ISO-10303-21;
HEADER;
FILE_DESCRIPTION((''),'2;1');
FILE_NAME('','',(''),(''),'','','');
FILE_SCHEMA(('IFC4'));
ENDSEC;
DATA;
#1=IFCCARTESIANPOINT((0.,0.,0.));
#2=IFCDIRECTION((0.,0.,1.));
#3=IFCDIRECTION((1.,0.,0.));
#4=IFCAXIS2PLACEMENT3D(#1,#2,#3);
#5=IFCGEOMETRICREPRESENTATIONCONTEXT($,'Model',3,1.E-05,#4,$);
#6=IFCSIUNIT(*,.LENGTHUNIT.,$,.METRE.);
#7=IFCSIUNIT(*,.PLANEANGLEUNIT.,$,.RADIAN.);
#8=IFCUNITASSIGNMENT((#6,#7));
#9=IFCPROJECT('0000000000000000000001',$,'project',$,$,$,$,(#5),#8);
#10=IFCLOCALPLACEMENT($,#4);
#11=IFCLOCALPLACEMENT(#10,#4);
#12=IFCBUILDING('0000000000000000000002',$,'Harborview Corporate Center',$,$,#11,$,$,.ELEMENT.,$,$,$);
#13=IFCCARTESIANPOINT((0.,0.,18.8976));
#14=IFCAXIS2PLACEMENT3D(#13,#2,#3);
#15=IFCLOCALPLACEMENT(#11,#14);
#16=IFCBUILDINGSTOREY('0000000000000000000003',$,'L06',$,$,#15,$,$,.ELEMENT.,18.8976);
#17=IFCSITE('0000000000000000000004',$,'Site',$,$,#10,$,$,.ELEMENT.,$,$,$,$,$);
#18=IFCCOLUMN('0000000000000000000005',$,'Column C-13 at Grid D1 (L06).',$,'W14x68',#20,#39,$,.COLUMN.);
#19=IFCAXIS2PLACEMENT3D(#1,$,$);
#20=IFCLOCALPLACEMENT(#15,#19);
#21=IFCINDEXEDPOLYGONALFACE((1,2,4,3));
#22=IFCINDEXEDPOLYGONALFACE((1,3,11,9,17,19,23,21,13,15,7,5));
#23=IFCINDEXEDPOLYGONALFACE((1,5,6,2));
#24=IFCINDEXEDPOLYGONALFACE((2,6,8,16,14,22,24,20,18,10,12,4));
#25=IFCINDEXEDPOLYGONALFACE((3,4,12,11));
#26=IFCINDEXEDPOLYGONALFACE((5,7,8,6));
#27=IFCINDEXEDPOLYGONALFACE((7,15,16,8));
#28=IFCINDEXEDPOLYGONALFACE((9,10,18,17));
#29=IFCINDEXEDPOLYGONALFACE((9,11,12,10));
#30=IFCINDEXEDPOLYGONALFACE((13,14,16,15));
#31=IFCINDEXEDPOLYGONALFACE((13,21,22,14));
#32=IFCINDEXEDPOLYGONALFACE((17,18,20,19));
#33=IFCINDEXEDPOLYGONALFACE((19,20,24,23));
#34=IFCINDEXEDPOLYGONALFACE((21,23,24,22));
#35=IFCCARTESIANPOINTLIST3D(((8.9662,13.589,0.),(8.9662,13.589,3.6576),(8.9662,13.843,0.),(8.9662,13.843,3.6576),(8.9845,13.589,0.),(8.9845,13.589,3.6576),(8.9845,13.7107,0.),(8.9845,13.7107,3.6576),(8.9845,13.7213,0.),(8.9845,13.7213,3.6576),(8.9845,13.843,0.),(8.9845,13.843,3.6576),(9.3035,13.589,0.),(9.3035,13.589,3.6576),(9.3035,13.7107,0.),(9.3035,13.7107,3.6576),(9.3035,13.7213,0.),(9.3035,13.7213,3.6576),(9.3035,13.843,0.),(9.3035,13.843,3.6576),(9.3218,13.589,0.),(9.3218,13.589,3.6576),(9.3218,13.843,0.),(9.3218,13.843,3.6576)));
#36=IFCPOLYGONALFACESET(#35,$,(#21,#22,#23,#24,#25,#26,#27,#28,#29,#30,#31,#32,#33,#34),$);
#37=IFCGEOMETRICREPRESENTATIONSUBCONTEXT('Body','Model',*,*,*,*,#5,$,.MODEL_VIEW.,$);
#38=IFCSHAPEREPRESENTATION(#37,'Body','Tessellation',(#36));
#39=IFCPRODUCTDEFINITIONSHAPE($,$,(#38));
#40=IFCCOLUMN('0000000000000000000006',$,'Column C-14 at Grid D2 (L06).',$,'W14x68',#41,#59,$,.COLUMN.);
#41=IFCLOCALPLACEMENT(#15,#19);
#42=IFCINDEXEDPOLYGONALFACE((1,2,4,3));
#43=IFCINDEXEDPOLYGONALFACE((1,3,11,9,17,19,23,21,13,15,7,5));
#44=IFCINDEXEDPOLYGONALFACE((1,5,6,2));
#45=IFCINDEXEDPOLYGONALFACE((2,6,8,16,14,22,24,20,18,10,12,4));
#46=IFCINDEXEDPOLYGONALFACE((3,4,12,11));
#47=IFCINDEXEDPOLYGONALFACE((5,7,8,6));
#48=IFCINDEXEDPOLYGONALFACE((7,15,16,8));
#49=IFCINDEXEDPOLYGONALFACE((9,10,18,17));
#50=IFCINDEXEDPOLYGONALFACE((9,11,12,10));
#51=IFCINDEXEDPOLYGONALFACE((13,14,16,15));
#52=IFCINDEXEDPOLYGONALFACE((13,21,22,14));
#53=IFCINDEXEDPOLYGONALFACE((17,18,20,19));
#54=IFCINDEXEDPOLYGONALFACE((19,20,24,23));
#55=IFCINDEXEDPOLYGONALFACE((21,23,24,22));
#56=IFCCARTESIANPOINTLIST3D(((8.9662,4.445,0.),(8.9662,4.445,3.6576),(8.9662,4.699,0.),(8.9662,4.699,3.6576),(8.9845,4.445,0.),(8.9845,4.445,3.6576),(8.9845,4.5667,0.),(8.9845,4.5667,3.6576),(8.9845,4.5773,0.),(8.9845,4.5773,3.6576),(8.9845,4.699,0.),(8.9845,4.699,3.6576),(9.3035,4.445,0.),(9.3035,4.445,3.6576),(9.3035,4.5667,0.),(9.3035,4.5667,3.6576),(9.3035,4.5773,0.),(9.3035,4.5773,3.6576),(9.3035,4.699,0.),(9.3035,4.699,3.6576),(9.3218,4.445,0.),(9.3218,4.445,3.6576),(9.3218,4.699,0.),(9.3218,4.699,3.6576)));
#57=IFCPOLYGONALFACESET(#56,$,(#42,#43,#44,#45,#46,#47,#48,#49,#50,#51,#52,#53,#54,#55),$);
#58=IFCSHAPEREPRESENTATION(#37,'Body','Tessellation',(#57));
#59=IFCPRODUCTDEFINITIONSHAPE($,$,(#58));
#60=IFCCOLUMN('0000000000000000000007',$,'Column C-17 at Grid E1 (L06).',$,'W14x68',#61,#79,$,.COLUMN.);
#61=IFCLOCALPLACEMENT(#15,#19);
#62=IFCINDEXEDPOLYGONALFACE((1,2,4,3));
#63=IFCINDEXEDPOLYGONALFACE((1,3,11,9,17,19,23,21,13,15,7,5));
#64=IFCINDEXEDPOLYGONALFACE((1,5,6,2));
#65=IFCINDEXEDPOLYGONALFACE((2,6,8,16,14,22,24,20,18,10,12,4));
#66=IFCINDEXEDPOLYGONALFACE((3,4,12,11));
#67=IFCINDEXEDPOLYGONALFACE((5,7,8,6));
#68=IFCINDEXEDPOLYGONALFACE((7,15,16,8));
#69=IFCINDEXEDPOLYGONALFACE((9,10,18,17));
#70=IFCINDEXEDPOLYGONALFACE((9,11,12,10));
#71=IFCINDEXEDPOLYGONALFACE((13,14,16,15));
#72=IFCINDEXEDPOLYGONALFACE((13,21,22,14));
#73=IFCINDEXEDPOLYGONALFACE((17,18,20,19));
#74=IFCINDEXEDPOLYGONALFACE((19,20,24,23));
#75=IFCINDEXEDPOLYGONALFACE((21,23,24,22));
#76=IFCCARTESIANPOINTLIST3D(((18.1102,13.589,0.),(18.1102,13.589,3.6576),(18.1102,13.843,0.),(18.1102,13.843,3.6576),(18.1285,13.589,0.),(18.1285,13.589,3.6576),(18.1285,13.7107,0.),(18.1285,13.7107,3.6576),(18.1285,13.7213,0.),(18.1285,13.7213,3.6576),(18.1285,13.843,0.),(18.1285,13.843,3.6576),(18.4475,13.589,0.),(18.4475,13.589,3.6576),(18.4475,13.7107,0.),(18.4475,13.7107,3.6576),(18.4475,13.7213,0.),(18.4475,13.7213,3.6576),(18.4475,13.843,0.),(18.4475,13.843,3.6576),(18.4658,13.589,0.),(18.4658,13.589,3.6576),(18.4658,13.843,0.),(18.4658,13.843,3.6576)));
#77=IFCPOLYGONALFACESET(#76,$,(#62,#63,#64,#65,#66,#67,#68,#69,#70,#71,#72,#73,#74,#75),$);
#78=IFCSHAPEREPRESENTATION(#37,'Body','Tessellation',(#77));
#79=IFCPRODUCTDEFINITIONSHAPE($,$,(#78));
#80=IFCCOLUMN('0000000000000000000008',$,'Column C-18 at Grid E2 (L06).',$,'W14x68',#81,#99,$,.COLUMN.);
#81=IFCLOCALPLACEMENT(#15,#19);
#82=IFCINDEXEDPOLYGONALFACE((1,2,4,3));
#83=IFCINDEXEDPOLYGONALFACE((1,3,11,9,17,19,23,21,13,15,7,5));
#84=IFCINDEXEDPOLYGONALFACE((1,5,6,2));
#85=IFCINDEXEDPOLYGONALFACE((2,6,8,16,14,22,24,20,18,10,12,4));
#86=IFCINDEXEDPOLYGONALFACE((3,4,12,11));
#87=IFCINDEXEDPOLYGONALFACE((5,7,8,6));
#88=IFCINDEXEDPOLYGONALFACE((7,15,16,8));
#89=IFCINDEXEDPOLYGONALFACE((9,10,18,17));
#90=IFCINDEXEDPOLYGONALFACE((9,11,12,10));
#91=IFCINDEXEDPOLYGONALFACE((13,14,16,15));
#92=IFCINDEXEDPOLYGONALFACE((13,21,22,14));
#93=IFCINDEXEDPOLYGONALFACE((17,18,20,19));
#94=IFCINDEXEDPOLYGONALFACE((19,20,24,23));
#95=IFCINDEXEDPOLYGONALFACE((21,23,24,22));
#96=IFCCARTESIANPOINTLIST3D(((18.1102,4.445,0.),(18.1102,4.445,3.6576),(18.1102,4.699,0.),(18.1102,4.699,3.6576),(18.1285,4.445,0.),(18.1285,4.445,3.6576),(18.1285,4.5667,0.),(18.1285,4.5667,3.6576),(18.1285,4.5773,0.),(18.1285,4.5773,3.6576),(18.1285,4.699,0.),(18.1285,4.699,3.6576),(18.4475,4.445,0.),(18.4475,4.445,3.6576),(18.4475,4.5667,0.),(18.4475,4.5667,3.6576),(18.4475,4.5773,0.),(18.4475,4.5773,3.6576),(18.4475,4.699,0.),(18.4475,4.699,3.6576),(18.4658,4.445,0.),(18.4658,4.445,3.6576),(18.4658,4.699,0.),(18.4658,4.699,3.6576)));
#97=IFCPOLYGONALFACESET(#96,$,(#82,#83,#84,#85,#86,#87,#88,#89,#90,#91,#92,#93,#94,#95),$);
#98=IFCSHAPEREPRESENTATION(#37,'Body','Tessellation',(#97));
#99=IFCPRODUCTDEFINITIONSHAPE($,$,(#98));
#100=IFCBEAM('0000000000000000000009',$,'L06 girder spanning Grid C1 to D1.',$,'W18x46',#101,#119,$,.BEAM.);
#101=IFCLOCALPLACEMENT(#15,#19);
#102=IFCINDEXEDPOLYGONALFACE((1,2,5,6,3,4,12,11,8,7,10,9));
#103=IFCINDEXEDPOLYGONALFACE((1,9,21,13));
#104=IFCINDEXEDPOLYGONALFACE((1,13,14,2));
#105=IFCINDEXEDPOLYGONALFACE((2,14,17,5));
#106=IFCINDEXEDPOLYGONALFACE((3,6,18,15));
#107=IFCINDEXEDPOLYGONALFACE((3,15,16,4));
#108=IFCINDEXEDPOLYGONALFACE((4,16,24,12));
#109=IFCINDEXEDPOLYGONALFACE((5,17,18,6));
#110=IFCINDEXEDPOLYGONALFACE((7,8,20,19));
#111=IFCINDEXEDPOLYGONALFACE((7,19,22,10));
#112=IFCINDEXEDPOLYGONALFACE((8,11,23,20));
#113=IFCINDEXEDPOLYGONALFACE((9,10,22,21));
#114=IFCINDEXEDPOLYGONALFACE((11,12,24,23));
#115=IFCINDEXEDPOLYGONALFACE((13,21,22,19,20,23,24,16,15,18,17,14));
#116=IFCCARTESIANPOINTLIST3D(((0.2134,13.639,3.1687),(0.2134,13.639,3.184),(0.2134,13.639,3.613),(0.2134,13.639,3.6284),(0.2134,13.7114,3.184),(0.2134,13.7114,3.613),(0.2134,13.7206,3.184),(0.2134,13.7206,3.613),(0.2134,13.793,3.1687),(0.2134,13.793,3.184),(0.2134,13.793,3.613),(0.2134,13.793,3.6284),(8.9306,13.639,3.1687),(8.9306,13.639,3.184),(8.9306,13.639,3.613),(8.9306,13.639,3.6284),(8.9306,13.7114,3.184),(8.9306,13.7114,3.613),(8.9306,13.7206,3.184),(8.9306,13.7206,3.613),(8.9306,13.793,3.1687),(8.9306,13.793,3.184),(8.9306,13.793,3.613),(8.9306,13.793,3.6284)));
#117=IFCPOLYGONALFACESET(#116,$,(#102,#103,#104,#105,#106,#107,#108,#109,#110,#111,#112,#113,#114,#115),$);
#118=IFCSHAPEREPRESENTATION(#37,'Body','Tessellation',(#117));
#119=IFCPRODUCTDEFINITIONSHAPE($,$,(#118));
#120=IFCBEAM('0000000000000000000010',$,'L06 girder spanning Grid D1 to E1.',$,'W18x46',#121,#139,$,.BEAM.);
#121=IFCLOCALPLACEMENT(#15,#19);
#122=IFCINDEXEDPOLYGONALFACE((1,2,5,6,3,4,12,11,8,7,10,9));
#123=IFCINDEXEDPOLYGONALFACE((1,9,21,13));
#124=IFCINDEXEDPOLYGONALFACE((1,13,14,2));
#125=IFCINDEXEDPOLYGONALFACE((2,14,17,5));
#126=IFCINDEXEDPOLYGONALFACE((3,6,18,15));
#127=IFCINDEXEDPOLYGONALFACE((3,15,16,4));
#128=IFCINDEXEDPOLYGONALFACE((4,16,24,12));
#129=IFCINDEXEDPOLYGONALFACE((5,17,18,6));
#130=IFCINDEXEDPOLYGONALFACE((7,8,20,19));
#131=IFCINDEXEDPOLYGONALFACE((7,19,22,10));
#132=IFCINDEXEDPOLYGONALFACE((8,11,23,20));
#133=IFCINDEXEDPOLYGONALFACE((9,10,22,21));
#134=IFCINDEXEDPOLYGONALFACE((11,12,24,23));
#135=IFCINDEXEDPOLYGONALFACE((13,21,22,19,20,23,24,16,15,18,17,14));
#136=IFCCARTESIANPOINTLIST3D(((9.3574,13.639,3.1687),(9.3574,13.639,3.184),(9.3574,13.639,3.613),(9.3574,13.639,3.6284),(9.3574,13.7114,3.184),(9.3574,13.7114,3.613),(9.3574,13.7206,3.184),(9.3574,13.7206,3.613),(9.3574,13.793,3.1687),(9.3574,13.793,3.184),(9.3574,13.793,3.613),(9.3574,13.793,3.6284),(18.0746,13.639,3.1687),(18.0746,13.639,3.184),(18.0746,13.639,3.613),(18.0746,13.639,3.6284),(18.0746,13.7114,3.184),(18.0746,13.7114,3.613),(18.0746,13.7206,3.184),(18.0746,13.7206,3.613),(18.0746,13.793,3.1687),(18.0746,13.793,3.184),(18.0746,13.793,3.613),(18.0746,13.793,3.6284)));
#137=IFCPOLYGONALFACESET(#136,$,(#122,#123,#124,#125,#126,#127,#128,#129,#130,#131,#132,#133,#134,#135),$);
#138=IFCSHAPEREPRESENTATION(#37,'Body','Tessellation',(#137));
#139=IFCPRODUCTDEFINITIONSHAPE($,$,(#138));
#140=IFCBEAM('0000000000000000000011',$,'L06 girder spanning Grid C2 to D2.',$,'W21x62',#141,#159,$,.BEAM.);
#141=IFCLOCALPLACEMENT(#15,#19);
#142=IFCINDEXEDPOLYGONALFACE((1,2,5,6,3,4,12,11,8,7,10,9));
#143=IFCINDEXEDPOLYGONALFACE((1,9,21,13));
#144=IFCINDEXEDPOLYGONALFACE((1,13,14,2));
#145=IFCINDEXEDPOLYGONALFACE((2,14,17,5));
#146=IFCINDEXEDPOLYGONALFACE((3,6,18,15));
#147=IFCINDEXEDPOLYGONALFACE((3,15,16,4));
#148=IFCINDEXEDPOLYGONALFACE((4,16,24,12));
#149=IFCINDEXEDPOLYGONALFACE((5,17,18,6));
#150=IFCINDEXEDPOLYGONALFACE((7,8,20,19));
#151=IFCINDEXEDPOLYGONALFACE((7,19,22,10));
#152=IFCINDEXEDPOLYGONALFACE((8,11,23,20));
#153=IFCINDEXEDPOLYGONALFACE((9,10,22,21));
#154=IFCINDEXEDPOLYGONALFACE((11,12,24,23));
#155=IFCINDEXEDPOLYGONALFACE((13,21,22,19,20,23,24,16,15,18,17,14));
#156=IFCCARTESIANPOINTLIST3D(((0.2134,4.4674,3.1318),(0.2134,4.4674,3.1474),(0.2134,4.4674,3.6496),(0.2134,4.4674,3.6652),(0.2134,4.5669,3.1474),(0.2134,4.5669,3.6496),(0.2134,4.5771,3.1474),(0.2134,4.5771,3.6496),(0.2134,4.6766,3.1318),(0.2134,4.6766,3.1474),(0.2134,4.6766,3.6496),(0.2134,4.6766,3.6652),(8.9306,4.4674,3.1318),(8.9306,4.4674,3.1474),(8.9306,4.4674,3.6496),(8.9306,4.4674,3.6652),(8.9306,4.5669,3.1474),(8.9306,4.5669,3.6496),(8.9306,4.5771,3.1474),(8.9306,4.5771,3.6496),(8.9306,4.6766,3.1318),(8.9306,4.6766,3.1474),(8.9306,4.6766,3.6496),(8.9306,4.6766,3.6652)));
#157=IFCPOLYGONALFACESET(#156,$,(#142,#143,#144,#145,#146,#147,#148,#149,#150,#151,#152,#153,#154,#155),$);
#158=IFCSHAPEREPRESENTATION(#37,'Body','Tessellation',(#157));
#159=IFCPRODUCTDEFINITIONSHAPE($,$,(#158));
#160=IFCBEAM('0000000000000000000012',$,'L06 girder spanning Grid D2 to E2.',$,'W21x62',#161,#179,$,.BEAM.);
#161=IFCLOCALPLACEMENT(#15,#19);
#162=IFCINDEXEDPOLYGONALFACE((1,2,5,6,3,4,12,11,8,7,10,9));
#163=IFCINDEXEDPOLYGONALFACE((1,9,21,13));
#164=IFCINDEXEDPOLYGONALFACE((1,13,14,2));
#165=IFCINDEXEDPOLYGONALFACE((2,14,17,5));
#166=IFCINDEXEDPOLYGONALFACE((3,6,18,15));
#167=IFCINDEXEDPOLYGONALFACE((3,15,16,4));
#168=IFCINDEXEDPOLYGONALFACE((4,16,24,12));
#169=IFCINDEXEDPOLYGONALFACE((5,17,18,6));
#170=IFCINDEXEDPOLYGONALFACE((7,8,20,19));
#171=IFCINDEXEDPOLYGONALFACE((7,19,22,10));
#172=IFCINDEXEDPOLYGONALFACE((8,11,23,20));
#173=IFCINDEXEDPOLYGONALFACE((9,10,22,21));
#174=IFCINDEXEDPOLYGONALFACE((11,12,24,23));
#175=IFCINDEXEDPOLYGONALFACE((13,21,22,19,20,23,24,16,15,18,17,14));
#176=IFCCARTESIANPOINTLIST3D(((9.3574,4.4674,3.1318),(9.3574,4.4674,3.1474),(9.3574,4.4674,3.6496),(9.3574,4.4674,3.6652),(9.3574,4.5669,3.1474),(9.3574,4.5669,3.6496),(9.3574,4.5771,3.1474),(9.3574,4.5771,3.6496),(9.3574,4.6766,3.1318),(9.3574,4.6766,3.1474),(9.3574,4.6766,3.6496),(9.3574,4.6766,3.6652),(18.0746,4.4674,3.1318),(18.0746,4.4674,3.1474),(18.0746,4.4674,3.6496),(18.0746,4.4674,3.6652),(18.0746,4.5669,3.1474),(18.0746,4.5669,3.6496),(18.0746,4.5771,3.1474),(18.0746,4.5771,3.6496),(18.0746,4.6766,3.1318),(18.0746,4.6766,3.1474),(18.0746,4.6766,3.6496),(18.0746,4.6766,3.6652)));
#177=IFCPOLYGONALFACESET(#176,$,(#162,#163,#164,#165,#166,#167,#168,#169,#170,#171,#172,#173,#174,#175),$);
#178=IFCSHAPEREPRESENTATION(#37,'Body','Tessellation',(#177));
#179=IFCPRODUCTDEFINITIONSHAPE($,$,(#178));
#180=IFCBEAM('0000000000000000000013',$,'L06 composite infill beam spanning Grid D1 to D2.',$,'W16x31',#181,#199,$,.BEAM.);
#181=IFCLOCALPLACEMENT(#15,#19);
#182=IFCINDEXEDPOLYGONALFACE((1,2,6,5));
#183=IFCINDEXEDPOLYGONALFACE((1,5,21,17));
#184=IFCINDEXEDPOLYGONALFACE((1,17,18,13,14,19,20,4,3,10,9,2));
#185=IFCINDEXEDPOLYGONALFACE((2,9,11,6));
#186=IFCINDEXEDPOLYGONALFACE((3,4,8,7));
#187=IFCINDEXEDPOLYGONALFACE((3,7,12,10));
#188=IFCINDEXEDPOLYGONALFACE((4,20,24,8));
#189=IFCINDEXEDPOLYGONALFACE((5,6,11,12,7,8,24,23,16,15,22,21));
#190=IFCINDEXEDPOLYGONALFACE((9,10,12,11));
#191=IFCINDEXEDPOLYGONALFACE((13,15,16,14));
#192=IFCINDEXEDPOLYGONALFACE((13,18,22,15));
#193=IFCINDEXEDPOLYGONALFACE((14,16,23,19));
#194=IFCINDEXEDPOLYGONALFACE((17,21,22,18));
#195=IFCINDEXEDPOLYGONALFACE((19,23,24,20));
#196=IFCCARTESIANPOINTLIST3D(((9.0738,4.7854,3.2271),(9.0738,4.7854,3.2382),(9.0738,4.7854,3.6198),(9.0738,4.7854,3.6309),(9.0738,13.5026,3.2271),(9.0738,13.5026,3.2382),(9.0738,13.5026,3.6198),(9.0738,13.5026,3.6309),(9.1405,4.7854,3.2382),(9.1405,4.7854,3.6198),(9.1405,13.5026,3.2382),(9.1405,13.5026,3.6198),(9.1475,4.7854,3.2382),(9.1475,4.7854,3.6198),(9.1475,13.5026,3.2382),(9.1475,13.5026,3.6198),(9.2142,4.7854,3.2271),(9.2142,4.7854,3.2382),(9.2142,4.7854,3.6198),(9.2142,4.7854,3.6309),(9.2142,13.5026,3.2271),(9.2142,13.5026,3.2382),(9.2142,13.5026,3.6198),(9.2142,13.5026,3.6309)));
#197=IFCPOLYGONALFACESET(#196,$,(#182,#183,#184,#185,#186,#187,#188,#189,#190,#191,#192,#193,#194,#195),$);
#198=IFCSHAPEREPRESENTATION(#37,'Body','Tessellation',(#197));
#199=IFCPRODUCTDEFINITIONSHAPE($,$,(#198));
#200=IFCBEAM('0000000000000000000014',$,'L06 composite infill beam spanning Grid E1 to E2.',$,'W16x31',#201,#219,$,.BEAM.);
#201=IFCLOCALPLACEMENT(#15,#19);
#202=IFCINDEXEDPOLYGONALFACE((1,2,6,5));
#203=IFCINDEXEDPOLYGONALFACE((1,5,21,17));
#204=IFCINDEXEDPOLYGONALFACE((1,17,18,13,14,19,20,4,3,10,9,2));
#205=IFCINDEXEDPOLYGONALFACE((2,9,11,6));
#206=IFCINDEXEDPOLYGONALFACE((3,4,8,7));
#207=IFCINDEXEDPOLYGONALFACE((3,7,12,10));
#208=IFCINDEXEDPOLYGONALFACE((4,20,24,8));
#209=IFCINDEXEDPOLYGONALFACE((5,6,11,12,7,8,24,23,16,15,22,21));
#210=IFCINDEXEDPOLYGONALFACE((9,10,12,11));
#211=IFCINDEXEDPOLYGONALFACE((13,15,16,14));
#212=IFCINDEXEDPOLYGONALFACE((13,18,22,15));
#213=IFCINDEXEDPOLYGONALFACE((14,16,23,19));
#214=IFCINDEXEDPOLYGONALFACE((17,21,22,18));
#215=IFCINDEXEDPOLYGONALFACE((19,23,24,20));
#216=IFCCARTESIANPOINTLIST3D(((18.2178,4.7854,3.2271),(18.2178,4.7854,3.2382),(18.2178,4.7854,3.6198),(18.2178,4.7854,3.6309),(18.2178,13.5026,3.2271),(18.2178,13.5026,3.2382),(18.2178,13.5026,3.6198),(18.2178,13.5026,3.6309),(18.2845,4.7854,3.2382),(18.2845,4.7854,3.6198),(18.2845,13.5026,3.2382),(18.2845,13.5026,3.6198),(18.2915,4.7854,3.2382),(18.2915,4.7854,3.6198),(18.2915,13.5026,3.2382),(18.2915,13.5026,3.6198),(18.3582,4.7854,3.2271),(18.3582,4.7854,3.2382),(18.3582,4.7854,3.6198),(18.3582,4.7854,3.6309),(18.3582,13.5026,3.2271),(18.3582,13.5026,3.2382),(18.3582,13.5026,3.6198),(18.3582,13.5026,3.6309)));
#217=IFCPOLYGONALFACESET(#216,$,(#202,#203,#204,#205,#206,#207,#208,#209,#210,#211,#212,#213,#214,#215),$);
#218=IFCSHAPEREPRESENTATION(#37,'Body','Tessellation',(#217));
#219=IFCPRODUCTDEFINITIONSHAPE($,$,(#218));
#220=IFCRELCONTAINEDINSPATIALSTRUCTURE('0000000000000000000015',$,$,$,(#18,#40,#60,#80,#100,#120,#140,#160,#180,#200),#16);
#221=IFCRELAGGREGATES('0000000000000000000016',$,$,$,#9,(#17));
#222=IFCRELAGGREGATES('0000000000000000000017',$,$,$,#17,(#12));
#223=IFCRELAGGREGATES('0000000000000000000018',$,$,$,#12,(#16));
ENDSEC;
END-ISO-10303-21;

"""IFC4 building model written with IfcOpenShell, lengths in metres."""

from ifc_helpers import new_model, si_unit, frame, origin_with_axes, place, context, subcontext, project, spatial, i_section, extrude, element, save


model = new_model("IFC4")

# Units and contexts
model_context = context("Model", 3, precision=1e-05, world=origin_with_axes())
body_context = subcontext(model_context, "Body", "Model", "MODEL_VIEW")
ifc_project = project(units=[si_unit("LENGTHUNIT", "METRE"), si_unit("PLANEANGLEUNIT", "RADIAN")], contexts=[model_context])

# Site, building, storey
site_placement = place(None, origin_with_axes())
site = spatial("IfcSite", under=ifc_project, at=site_placement, Name="Site", CompositionType="ELEMENT")
building_placement = place(site_placement, origin_with_axes())
building = spatial("IfcBuilding", under=site, at=building_placement, Name="Harborview Corporate Center", CompositionType="ELEMENT")
storey_placement = place(building_placement, frame((0.0, 0.0, 18.8976), z_axis=(0.0, 0.0, 1.0), x_axis=(1.0, 0.0, 0.0)))
storey = spatial("IfcBuildingStorey", under=building, at=storey_placement, Name="L06", CompositionType="ELEMENT", Elevation=18.8976)

# Columns
for number, where, z_axis, x_axis, name in (
    (1, (9.144, 13.716, 0.0), (0.0, 0.0, 1.0), (0.0, 1.0, 0.0), "Column C-13 at Grid D1 (L06)."),
    (2, (9.144, 4.572, 0.0), (0.0, 0.0, 1.0), (0.0, 1.0, 0.0), "Column C-14 at Grid D2 (L06)."),
    (3, (18.288, 13.716, 0.0), (0.0, 0.0, 1.0), (0.0, 1.0, 0.0), "Column C-17 at Grid E1 (L06)."),
    (4, (18.288, 4.572, 0.0), (0.0, 0.0, 1.0), (0.0, 1.0, 0.0), "Column C-18 at Grid E2 (L06)."),
):
    element("IfcColumn", number, at=place(storey_placement, frame(where, z_axis=z_axis, x_axis=x_axis)), inside=storey, Name=name, ObjectType="W14x68", PredefinedType="COLUMN", context=body_context, shape_type="SweptSolid", body=[
        extrude(i_section(OverallWidth=0.254, OverallDepth=0.3556, WebThickness=0.0105, FlangeThickness=0.0183), origin_with_axes(), (0.0, 0.0, 1.0), 3.6576),
    ])

# Beams
beam_1_placement = place(storey_placement, frame((0.2134, 13.716, 3.3985), z_axis=(1.0, 0.0, 0.0), x_axis=(0.0, 1.0, 0.0)))
element("IfcBeam", 5, at=beam_1_placement, inside=storey, Name="L06 girder spanning Grid C1 to D1.", ObjectType="W18x46", PredefinedType="BEAM", context=body_context, shape_type="SweptSolid", body=[
    extrude(i_section(OverallWidth=0.1539, OverallDepth=0.4597, WebThickness=0.0091, FlangeThickness=0.0154), origin_with_axes(), (0.0, 0.0, 1.0), 8.7173),
])
beam_2_placement = place(storey_placement, frame((9.3574, 13.716, 3.3985), z_axis=(1.0, 0.0, 0.0), x_axis=(0.0, 1.0, 0.0)))
element("IfcBeam", 6, at=beam_2_placement, inside=storey, Name="L06 girder spanning Grid D1 to E1.", ObjectType="W18x46", PredefinedType="BEAM", context=body_context, shape_type="SweptSolid", body=[
    extrude(i_section(OverallWidth=0.1539, OverallDepth=0.4597, WebThickness=0.0091, FlangeThickness=0.0154), origin_with_axes(), (0.0, 0.0, 1.0), 8.7173),
])
beam_3_placement = place(storey_placement, frame((0.2134, 4.572, 3.3985), z_axis=(1.0, 0.0, 0.0), x_axis=(0.0, 1.0, 0.0)))
element("IfcBeam", 7, at=beam_3_placement, inside=storey, Name="L06 girder spanning Grid C2 to D2.", ObjectType="W21x62", PredefinedType="BEAM", context=body_context, shape_type="SweptSolid", body=[
    extrude(i_section(OverallWidth=0.2093, OverallDepth=0.5334, WebThickness=0.0102, FlangeThickness=0.0156), origin_with_axes(), (0.0, 0.0, 1.0), 8.7173),
])
beam_4_placement = place(storey_placement, frame((9.3574, 4.572, 3.3985), z_axis=(1.0, 0.0, 0.0), x_axis=(0.0, 1.0, 0.0)))
element("IfcBeam", 8, at=beam_4_placement, inside=storey, Name="L06 girder spanning Grid D2 to E2.", ObjectType="W21x62", PredefinedType="BEAM", context=body_context, shape_type="SweptSolid", body=[
    extrude(i_section(OverallWidth=0.2093, OverallDepth=0.5334, WebThickness=0.0102, FlangeThickness=0.0156), origin_with_axes(), (0.0, 0.0, 1.0), 8.7173),
])
for number, where, z_axis, x_axis, name in (
    (9, (9.144, 4.7854, 3.429), (0.0, 1.0, 0.0), (-1.0, 0.0, 0.0), "L06 composite infill beam spanning Grid D1 to D2."),
    (10, (18.288, 4.7854, 3.429), (0.0, 1.0, 0.0), (-1.0, 0.0, 0.0), "L06 composite infill beam spanning Grid E1 to E2."),
):
    element("IfcBeam", number, at=place(storey_placement, frame(where, z_axis=z_axis, x_axis=x_axis)), inside=storey, Name=name, ObjectType="W16x31", PredefinedType="BEAM", context=body_context, shape_type="SweptSolid", body=[
        extrude(i_section(OverallWidth=0.1405, OverallDepth=0.4039, WebThickness=0.007, FlangeThickness=0.0112), origin_with_axes(), (0.0, 0.0, 1.0), 8.7173),
    ])

save(model, "model.ifc")
